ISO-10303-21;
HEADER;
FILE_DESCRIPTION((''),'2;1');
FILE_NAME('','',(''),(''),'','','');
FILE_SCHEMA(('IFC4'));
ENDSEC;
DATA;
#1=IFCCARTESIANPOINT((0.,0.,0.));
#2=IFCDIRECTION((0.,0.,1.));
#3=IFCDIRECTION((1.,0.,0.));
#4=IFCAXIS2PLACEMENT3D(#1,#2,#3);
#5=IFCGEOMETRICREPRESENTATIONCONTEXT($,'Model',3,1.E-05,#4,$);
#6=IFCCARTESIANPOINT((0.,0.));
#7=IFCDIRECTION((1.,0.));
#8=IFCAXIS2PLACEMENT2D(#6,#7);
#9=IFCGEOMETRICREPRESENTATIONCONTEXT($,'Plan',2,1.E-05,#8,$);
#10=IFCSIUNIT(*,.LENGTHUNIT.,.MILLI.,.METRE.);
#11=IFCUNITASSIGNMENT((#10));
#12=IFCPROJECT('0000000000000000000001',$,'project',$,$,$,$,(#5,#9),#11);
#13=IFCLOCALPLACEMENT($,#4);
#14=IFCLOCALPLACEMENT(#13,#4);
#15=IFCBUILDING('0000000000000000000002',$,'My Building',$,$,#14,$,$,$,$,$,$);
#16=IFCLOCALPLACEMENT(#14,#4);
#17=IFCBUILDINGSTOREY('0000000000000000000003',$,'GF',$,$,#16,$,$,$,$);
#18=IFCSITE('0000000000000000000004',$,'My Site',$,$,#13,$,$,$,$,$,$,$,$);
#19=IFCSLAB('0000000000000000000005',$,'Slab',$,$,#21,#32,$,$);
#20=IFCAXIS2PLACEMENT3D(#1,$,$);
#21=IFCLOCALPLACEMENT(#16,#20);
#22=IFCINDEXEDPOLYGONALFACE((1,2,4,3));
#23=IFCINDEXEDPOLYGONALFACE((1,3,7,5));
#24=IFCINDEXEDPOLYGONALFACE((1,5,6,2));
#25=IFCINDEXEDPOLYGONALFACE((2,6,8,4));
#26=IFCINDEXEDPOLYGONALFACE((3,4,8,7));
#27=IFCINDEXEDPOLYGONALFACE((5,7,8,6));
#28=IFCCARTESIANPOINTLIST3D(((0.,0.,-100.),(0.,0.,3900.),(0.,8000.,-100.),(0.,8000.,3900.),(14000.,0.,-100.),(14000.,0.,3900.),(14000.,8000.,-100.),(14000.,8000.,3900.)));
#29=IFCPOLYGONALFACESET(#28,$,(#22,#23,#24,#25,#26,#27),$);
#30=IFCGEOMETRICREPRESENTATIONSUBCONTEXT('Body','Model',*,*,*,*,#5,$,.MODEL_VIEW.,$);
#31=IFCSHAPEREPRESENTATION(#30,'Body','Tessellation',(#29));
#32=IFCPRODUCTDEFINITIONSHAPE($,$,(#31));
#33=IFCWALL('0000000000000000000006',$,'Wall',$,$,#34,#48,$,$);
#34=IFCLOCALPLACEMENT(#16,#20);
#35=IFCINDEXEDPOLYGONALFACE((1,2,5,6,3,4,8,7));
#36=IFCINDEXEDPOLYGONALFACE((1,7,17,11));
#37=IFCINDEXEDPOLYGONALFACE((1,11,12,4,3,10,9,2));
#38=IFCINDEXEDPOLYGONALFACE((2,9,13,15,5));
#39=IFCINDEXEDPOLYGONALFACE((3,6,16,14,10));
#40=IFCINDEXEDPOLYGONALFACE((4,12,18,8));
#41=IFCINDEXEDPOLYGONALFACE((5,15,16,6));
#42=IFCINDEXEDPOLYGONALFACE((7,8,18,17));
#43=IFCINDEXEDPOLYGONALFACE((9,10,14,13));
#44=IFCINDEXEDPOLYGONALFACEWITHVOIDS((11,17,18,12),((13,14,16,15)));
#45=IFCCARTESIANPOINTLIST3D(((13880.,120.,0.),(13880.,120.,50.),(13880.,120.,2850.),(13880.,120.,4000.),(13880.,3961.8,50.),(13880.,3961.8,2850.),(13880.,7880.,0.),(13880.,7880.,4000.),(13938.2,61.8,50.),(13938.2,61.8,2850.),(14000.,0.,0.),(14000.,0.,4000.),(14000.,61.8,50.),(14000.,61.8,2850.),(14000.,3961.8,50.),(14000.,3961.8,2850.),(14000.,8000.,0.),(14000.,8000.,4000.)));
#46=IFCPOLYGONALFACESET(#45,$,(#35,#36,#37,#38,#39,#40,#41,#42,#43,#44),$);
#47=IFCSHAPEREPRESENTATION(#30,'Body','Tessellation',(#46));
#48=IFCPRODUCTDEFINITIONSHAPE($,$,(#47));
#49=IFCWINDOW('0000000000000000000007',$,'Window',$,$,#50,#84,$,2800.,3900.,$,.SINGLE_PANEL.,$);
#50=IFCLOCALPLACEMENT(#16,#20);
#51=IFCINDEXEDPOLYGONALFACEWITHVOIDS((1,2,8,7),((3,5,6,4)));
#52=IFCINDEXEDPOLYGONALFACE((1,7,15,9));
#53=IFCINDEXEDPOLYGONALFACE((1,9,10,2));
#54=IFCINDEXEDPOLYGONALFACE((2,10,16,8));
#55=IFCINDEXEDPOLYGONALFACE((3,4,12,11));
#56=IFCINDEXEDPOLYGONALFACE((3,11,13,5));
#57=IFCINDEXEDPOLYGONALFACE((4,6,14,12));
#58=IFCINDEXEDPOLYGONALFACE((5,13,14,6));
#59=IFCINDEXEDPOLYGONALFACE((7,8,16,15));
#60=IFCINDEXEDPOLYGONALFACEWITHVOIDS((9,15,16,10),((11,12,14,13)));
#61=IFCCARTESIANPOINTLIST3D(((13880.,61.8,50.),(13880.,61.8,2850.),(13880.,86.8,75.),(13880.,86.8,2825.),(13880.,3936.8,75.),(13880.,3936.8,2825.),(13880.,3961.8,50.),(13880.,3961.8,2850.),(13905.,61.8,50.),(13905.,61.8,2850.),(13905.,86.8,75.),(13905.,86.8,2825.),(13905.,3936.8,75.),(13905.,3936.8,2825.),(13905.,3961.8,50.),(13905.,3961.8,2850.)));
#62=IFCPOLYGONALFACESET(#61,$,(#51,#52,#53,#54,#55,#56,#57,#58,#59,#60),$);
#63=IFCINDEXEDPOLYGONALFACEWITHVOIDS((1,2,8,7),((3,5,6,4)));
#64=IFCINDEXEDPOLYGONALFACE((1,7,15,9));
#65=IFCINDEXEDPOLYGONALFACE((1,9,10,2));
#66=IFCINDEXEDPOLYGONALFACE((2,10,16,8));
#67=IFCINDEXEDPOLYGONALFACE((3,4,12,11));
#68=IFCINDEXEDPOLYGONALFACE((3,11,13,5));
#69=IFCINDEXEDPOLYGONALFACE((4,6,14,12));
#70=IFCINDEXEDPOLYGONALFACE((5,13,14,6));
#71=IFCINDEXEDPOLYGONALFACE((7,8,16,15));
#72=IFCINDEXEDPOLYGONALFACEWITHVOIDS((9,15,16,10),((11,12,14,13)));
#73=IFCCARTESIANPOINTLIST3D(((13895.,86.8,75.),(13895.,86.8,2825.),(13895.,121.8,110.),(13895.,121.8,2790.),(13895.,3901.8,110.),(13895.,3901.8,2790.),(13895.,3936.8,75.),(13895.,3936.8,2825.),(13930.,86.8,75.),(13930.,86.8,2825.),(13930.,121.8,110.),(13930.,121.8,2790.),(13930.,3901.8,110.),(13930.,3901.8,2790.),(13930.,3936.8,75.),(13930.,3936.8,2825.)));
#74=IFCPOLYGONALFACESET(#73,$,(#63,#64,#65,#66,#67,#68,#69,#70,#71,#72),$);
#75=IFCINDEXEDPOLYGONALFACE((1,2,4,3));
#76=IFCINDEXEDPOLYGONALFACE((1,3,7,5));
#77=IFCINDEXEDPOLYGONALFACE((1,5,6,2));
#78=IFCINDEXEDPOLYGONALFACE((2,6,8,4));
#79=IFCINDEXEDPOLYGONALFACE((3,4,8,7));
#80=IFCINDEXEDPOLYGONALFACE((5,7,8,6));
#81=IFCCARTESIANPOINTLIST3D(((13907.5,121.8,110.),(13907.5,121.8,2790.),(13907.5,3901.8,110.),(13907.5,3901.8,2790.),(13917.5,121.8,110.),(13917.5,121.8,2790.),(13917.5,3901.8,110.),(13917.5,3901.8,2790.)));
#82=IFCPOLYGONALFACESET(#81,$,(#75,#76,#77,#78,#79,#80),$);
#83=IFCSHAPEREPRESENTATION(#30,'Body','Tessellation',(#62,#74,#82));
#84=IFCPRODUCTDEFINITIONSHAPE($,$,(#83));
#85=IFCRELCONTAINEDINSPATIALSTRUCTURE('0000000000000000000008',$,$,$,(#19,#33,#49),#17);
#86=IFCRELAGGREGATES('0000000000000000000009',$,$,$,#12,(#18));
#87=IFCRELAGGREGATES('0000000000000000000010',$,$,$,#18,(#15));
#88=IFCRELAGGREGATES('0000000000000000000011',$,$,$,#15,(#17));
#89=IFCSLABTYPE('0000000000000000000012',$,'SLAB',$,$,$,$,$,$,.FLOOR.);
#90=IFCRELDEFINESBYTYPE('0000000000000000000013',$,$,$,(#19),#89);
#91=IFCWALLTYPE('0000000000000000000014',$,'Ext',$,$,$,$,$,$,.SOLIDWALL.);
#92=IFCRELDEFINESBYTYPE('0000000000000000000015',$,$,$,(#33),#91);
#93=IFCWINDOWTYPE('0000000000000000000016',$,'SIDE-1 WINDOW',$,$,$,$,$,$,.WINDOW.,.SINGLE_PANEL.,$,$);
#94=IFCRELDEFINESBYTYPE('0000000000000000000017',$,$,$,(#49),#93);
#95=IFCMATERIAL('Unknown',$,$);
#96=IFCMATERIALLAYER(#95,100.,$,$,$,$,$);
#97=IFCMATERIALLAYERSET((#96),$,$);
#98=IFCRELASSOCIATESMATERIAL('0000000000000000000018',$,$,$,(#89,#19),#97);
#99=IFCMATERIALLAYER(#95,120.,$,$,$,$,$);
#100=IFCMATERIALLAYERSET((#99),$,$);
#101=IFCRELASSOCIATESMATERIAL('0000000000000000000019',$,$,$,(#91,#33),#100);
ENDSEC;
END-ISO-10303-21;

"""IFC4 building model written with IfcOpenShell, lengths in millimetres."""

from ifc_helpers import new_model, entity, si_unit, frame, origin_with_axes, origin_2d_with_axis, place, context, subcontext, project, spatial, line, indexed_curve, outline, extrude, shape, source, transform, mapped, material, layer, layer_set, layer_usage, type_object, type_shapes, element, fill, save


model = new_model("IFC4")

# Units and contexts
model_context = context("Model", 3, precision=1e-05, world=origin_with_axes())
plan_context = context("Plan", 2, precision=1e-05, world=origin_2d_with_axis())
body_context_1 = subcontext(model_context, "Body", "Model", "MODEL_VIEW")
body_context_2 = subcontext(plan_context, "Body", "Plan", "PLAN_VIEW")
ifc_project = project(units=[si_unit("LENGTHUNIT", "METRE", prefix="MILLI")], contexts=[model_context, plan_context])

# Site, building, storey
site_placement = place(None, origin_with_axes())
site = spatial("IfcSite", under=ifc_project, at=site_placement, Name="My Site")
building_placement = place(site_placement, origin_with_axes())
building = spatial("IfcBuilding", under=site, at=building_placement, Name="My Building")
storey_placement = place(building_placement, origin_with_axes())
storey = spatial("IfcBuildingStorey", under=building, at=storey_placement, Name="GF")

# Slab
ifc_material = material(Name="Unknown")
ifc_layer_1 = layer(ifc_material, 100.0)
ifc_layer_set_1 = layer_set([ifc_layer_1])
ifc_layer_usage_1 = layer_usage(ifc_layer_set_1, "AXIS3", "POSITIVE", -100.0)
slab_type = type_object("IfcSlabType", Name="SLAB", PredefinedType="FLOOR", material=ifc_layer_set_1)
slab_placement = place(storey_placement, frame((0.0, 8000.0, 0.0), z_axis=(0.0, 0.0, 1.0), x_axis=(1.0, 0.0, 0.0)))
element("IfcSlab", 1, at=slab_placement, inside=storey, type_object=slab_type, material=ifc_layer_usage_1, Name="Slab", context=body_context_1, shape_type="SweptSolid", body=[
    extrude(outline(indexed_curve([(0.0, 0.0), (14000.0, 0.0), (14000.0, -8000.0), (0.0, -8000.0), (0.0, 0.0)])), frame((0.0, 0.0, -100.0), z_axis=(0.0, 0.0, 1.0), x_axis=(1.0, 0.0, 0.0)), (0.0, 0.0, 1.0), 4000.0),
])

# Wall, opening, window
ifc_layer_2 = layer(ifc_material, 120.0)
ifc_layer_set_2 = layer_set([ifc_layer_2])
ifc_layer_usage_2 = layer_usage(ifc_layer_set_2, "AXIS2", "POSITIVE", 0.0)
wall_type_1 = type_object("IfcWallType", Name="Ext", PredefinedType="SOLIDWALL", material=ifc_layer_set_2)
wall_1_placement = place(storey_placement, frame((14000.0, 0.0, 0.0), z_axis=(0.0, 0.0, 1.0), x_axis=(0.0, 1.0, 0.0)))
wall_1 = element("IfcWall", 2, at=wall_1_placement, inside=storey, type_object=wall_type_1, material=ifc_layer_usage_2, Name="Wall", context=body_context_1, shape_type="SweptSolid", body=[
    extrude(outline(indexed_curve([(0.0, 0.0), (120.0, 120.0), (7880.0, 120.0), (8000.0, 0.0)], segments=[line(1, 2, 3, 4, 1)])), origin_with_axes(), (0.0, 0.0, 1.0), 4000.0),
])
shared_shape_1 = source(origin_with_axes(), body_context_1, "Body", "SweptSolid", [
    extrude(outline(indexed_curve([(0.0, 0.0), (3900.0, 0.0), (3900.0, 2800.0), (0.0, 2800.0)], segments=[line(1, 2, 3, 4, 1)])), frame((0.0, -600.0, 0.0), z_axis=(0.0, -1.0, 0.0), x_axis=(1.0, 0.0, 0.0)), (0.0, 0.0, -1.0), 1200.0),
])
opening_1_placement = place(wall_1_placement, frame((3961.8, 120.0, 50.0), z_axis=(0.0, 0.0, 1.0), x_axis=(-1.0, 0.0, 0.0)))
opening_1 = element("IfcOpeningElement", 3, at=opening_1_placement, cuts=wall_1, PredefinedType="OPENING", context=body_context_1, shape_type="MappedRepresentation", body=[
    mapped(shared_shape_1, transform((0.0, 0.0, 0.0), x_axis=(1.0, 0.0, 0.0), y_axis=(0.0, 1.0, 0.0), z_axis=(0.0, 0.0, 1.0), scale=1.0)),
])
window_type_1 = type_object("IfcWindowType", Name="SIDE-1 WINDOW", PartitioningType="SINGLE_PANEL", PredefinedType="WINDOW")
shared_shape_2 = source(origin_with_axes(), body_context_1, "Body", "SweptSolid", [
    extrude(outline(indexed_curve([(0.0, 0.0), (3900.0, 0.0), (3900.0, 2800.0), (0.0, 2800.0)], segments=[line(1, 2, 3, 4, 1)]), holes=[indexed_curve([(25.0, 25.0), (3875.0, 25.0), (3875.0, 2775.0), (25.0, 2775.0)], segments=[line(1, 2, 3, 4, 1)])]), frame((0.0, 0.0, 0.0), z_axis=(0.0, -1.0, 0.0), x_axis=(1.0, 0.0, 0.0)), (0.0, 0.0, -1.0), 25.0),
    extrude(outline(indexed_curve([(0.0, 0.0), (3850.0, 0.0), (3850.0, 2750.0), (0.0, 2750.0)], segments=[line(1, 2, 3, 4, 1)]), holes=[indexed_curve([(35.0, 35.0), (3815.0, 35.0), (3815.0, 2715.0), (35.0, 2715.0)], segments=[line(1, 2, 3, 4, 1)])]), frame((25.0, 15.0, 25.0), z_axis=(0.0, -1.0, 0.0), x_axis=(1.0, 0.0, 0.0)), (0.0, 0.0, -1.0), 35.0),
    extrude(outline(indexed_curve([(35.0, 35.0), (3815.0, 35.0), (3815.0, 2715.0), (35.0, 2715.0)], segments=[line(1, 2, 3, 4, 1)])), frame((25.0, 27.5, 25.0), z_axis=(0.0, -1.0, 0.0), x_axis=(1.0, 0.0, 0.0)), (0.0, 0.0, -1.0), 10.0),
])
shared_shape_3 = source(origin_with_axes(), body_context_2, "Body", "Curve2D", [
    entity("IfcIndexedPolyCurve", entity("IfcCartesianPointList2D", [[25.0, 0.0], [3875.0, 0.0]])),
    entity("IfcIndexedPolyCurve", entity("IfcCartesianPointList2D", [[0.0, 25.0], [25.0, 25.0], [25.0, 0.0], [0.0, 0.0]]), [entity("IfcLineIndex", [1, 2, 3, 4, 1])]),
    entity("IfcIndexedPolyCurve", entity("IfcCartesianPointList2D", [[3900.0, 25.0], [3875.0, 25.0], [3875.0, 0.0], [3900.0, 0.0]]), [entity("IfcLineIndex", [1, 2, 3, 4, 1])]),
    entity("IfcIndexedPolyCurve", entity("IfcCartesianPointList2D", [[25.0, 15.0], [60.0, 15.0], [60.0, 50.0], [25.0, 50.0]]), [entity("IfcLineIndex", [1, 2, 3, 4, 1])]),
    entity("IfcIndexedPolyCurve", entity("IfcCartesianPointList2D", [[3875.0, 15.0], [3840.0, 15.0], [3840.0, 50.0], [3875.0, 50.0]]), [entity("IfcLineIndex", [1, 2, 3, 4, 1])]),
    entity("IfcIndexedPolyCurve", entity("IfcCartesianPointList2D", [[60.0, 15.0], [3840.0, 15.0]])),
    entity("IfcIndexedPolyCurve", entity("IfcCartesianPointList2D", [[60.0, 50.0], [3840.0, 50.0]])),
    entity("IfcIndexedPolyCurve", entity("IfcCartesianPointList2D", [[60.0, 32.5], [3840.0, 32.5]])),
])
type_shapes(window_type_1, [shared_shape_2, shared_shape_3])
window_1_placement = place(opening_1_placement, frame((0.0, 0.0, 0.0), z_axis=(0.0, 0.0, 1.0), x_axis=(1.0, 0.0, 0.0)))
window_1 = element("IfcWindow", 4, at=window_1_placement, inside=storey, type_object=window_type_1, Name="Window", OverallHeight=2800.0, OverallWidth=3900.0, PartitioningType="SINGLE_PANEL", shapes=[
    shape(body_context_1, "Body", "MappedRepresentation", [mapped(shared_shape_2, transform((0.0, 0.0, 0.0), x_axis=(1.0, 0.0, 0.0), y_axis=(0.0, 1.0, 0.0), z_axis=(0.0, 0.0, 1.0), scale=1.0))]),
    shape(body_context_2, "Body", "MappedRepresentation", [mapped(shared_shape_3, transform((0.0, 0.0, 0.0), x_axis=(1.0, 0.0, 0.0), y_axis=(0.0, 1.0, 0.0), z_axis=(0.0, 0.0, 1.0), scale=1.0))]),
])
fill(opening_1, window_1)

save(model, "model.ifc")
